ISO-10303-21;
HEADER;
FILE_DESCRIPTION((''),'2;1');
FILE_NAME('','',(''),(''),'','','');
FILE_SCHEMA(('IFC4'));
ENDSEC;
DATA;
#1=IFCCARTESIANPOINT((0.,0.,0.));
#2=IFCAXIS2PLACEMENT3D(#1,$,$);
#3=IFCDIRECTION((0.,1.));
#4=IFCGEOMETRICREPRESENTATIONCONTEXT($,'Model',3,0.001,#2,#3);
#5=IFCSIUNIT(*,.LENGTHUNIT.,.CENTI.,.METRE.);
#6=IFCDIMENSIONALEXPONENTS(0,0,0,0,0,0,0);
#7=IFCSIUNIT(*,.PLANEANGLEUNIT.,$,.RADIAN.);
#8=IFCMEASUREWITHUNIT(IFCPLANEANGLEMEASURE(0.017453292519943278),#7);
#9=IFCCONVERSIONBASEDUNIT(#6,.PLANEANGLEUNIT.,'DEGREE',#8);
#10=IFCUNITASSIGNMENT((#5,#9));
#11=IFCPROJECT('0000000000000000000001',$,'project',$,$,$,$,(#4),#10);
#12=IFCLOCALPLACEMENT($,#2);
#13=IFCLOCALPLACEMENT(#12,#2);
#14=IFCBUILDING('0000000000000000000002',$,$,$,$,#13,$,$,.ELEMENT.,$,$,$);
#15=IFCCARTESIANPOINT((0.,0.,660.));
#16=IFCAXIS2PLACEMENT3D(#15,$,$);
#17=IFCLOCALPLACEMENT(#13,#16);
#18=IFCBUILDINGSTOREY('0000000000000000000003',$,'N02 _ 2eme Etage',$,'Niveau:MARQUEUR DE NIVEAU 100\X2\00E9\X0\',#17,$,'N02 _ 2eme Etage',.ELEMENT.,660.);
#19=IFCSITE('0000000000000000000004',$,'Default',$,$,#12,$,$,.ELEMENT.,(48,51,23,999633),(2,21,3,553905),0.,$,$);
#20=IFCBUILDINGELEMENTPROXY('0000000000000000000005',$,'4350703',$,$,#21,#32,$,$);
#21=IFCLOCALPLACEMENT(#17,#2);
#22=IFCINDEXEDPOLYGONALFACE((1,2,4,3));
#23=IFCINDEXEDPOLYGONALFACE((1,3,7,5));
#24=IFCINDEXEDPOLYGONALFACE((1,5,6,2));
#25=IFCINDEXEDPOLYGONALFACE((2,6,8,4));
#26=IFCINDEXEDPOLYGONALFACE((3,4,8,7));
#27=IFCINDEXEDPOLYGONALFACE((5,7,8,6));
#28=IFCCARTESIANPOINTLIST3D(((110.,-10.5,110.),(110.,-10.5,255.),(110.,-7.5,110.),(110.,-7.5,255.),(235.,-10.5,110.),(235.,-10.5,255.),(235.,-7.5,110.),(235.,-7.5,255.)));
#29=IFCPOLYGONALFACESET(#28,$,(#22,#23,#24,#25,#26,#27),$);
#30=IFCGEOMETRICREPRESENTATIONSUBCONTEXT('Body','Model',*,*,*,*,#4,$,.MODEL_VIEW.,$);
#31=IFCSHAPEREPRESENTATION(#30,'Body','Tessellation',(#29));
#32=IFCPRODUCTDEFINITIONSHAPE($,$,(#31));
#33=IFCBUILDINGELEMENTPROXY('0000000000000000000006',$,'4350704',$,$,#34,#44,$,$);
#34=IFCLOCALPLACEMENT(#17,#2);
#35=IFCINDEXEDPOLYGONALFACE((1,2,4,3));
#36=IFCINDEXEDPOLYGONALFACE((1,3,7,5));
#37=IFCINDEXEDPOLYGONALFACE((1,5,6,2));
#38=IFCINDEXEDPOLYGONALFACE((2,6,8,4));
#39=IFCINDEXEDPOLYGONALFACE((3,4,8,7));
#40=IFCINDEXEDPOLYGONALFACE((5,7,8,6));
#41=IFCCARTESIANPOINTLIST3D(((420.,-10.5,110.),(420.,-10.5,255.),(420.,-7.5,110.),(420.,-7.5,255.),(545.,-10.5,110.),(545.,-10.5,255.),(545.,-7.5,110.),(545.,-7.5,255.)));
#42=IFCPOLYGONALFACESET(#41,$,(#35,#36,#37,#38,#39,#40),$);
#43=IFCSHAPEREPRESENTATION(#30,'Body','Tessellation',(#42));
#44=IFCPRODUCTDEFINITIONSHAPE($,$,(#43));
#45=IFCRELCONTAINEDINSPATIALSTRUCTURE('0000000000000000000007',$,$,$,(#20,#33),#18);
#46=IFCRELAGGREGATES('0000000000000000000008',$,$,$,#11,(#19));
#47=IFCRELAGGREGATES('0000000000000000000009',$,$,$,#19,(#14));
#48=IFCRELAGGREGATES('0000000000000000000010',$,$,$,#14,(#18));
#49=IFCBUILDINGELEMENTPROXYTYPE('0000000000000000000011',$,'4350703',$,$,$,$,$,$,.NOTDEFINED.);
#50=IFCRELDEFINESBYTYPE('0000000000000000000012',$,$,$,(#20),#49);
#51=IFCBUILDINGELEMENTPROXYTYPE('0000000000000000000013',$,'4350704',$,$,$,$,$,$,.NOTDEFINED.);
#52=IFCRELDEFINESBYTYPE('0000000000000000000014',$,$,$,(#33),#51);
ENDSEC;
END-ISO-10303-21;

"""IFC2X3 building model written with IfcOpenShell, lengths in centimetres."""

from ifc_helpers import new_model, entity, si_unit, converted_unit, direction, frame, frame_2d, origin, place, context, subcontext, project, spatial, rectangle, extrude, type_object, element, save


model = new_model("IFC2X3")

# Units and contexts
model_context = context("Model", 3, precision=0.001, world=origin(), true_north=direction((0.0, 1.0)))
body_context = subcontext(model_context, "Body", "Model", "MODEL_VIEW")
ifc_project = project(units=[si_unit("LENGTHUNIT", "METRE", prefix="CENTI"), converted_unit("PLANEANGLEUNIT", "DEGREE", entity("IfcPlaneAngleMeasure", 0.017453292519943278), si_unit("PLANEANGLEUNIT", "RADIAN"), dimensions=[0, 0, 0, 0, 0, 0, 0])], contexts=[model_context])

# Site, building, storey
site_placement = place(None, origin())
site = spatial("IfcSite", under=ifc_project, at=site_placement, Name="Default", CompositionType="ELEMENT", RefLatitude=(48, 51, 23, 999633), RefLongitude=(2, 21, 3, 553905), RefElevation=0.0)
building_placement = place(site_placement, origin())
building = spatial("IfcBuilding", under=site, at=building_placement, CompositionType="ELEMENT")
storey_placement = place(building_placement, frame((0.0, 0.0, 660.0)))
storey = spatial("IfcBuildingStorey", under=building, at=storey_placement, Name="N02 _ 2eme Etage", ObjectType="Niveau:MARQUEUR DE NIVEAU 100é", LongName="N02 _ 2eme Etage", CompositionType="ELEMENT", Elevation=660.0)

# Building element proxies
building_element_proxy_type_1 = type_object("IfcBuildingElementProxyType", Name="4350703", PredefinedType="NOTDEFINED")
proxy_1_placement = place(storey_placement, origin())
element("IfcBuildingElementProxy", 1, at=proxy_1_placement, inside=storey, type_object=building_element_proxy_type_1, Name="4350703", context=body_context, shape_type="SweptSolid", body=[
    extrude(rectangle(XDim=125.0, YDim=3.0, at=frame_2d((0.0, 0.0), x_axis=(1.0, 0.0))), frame((172.5, -9.0, 110.0)), (0.0, 0.0, 1.0), 145.0),
])
building_element_proxy_type_2 = type_object("IfcBuildingElementProxyType", Name="4350704", PredefinedType="NOTDEFINED")
proxy_2_placement = place(storey_placement, origin())
element("IfcBuildingElementProxy", 2, at=proxy_2_placement, inside=storey, type_object=building_element_proxy_type_2, Name="4350704", context=body_context, shape_type="SweptSolid", body=[
    extrude(rectangle(XDim=125.0, YDim=3.0, at=frame_2d((0.0, 0.0), x_axis=(1.0, 0.0))), frame((482.5, -9.0, 110.0)), (0.0, 0.0, 1.0), 145.0),
])

save(model, "model.ifc")
